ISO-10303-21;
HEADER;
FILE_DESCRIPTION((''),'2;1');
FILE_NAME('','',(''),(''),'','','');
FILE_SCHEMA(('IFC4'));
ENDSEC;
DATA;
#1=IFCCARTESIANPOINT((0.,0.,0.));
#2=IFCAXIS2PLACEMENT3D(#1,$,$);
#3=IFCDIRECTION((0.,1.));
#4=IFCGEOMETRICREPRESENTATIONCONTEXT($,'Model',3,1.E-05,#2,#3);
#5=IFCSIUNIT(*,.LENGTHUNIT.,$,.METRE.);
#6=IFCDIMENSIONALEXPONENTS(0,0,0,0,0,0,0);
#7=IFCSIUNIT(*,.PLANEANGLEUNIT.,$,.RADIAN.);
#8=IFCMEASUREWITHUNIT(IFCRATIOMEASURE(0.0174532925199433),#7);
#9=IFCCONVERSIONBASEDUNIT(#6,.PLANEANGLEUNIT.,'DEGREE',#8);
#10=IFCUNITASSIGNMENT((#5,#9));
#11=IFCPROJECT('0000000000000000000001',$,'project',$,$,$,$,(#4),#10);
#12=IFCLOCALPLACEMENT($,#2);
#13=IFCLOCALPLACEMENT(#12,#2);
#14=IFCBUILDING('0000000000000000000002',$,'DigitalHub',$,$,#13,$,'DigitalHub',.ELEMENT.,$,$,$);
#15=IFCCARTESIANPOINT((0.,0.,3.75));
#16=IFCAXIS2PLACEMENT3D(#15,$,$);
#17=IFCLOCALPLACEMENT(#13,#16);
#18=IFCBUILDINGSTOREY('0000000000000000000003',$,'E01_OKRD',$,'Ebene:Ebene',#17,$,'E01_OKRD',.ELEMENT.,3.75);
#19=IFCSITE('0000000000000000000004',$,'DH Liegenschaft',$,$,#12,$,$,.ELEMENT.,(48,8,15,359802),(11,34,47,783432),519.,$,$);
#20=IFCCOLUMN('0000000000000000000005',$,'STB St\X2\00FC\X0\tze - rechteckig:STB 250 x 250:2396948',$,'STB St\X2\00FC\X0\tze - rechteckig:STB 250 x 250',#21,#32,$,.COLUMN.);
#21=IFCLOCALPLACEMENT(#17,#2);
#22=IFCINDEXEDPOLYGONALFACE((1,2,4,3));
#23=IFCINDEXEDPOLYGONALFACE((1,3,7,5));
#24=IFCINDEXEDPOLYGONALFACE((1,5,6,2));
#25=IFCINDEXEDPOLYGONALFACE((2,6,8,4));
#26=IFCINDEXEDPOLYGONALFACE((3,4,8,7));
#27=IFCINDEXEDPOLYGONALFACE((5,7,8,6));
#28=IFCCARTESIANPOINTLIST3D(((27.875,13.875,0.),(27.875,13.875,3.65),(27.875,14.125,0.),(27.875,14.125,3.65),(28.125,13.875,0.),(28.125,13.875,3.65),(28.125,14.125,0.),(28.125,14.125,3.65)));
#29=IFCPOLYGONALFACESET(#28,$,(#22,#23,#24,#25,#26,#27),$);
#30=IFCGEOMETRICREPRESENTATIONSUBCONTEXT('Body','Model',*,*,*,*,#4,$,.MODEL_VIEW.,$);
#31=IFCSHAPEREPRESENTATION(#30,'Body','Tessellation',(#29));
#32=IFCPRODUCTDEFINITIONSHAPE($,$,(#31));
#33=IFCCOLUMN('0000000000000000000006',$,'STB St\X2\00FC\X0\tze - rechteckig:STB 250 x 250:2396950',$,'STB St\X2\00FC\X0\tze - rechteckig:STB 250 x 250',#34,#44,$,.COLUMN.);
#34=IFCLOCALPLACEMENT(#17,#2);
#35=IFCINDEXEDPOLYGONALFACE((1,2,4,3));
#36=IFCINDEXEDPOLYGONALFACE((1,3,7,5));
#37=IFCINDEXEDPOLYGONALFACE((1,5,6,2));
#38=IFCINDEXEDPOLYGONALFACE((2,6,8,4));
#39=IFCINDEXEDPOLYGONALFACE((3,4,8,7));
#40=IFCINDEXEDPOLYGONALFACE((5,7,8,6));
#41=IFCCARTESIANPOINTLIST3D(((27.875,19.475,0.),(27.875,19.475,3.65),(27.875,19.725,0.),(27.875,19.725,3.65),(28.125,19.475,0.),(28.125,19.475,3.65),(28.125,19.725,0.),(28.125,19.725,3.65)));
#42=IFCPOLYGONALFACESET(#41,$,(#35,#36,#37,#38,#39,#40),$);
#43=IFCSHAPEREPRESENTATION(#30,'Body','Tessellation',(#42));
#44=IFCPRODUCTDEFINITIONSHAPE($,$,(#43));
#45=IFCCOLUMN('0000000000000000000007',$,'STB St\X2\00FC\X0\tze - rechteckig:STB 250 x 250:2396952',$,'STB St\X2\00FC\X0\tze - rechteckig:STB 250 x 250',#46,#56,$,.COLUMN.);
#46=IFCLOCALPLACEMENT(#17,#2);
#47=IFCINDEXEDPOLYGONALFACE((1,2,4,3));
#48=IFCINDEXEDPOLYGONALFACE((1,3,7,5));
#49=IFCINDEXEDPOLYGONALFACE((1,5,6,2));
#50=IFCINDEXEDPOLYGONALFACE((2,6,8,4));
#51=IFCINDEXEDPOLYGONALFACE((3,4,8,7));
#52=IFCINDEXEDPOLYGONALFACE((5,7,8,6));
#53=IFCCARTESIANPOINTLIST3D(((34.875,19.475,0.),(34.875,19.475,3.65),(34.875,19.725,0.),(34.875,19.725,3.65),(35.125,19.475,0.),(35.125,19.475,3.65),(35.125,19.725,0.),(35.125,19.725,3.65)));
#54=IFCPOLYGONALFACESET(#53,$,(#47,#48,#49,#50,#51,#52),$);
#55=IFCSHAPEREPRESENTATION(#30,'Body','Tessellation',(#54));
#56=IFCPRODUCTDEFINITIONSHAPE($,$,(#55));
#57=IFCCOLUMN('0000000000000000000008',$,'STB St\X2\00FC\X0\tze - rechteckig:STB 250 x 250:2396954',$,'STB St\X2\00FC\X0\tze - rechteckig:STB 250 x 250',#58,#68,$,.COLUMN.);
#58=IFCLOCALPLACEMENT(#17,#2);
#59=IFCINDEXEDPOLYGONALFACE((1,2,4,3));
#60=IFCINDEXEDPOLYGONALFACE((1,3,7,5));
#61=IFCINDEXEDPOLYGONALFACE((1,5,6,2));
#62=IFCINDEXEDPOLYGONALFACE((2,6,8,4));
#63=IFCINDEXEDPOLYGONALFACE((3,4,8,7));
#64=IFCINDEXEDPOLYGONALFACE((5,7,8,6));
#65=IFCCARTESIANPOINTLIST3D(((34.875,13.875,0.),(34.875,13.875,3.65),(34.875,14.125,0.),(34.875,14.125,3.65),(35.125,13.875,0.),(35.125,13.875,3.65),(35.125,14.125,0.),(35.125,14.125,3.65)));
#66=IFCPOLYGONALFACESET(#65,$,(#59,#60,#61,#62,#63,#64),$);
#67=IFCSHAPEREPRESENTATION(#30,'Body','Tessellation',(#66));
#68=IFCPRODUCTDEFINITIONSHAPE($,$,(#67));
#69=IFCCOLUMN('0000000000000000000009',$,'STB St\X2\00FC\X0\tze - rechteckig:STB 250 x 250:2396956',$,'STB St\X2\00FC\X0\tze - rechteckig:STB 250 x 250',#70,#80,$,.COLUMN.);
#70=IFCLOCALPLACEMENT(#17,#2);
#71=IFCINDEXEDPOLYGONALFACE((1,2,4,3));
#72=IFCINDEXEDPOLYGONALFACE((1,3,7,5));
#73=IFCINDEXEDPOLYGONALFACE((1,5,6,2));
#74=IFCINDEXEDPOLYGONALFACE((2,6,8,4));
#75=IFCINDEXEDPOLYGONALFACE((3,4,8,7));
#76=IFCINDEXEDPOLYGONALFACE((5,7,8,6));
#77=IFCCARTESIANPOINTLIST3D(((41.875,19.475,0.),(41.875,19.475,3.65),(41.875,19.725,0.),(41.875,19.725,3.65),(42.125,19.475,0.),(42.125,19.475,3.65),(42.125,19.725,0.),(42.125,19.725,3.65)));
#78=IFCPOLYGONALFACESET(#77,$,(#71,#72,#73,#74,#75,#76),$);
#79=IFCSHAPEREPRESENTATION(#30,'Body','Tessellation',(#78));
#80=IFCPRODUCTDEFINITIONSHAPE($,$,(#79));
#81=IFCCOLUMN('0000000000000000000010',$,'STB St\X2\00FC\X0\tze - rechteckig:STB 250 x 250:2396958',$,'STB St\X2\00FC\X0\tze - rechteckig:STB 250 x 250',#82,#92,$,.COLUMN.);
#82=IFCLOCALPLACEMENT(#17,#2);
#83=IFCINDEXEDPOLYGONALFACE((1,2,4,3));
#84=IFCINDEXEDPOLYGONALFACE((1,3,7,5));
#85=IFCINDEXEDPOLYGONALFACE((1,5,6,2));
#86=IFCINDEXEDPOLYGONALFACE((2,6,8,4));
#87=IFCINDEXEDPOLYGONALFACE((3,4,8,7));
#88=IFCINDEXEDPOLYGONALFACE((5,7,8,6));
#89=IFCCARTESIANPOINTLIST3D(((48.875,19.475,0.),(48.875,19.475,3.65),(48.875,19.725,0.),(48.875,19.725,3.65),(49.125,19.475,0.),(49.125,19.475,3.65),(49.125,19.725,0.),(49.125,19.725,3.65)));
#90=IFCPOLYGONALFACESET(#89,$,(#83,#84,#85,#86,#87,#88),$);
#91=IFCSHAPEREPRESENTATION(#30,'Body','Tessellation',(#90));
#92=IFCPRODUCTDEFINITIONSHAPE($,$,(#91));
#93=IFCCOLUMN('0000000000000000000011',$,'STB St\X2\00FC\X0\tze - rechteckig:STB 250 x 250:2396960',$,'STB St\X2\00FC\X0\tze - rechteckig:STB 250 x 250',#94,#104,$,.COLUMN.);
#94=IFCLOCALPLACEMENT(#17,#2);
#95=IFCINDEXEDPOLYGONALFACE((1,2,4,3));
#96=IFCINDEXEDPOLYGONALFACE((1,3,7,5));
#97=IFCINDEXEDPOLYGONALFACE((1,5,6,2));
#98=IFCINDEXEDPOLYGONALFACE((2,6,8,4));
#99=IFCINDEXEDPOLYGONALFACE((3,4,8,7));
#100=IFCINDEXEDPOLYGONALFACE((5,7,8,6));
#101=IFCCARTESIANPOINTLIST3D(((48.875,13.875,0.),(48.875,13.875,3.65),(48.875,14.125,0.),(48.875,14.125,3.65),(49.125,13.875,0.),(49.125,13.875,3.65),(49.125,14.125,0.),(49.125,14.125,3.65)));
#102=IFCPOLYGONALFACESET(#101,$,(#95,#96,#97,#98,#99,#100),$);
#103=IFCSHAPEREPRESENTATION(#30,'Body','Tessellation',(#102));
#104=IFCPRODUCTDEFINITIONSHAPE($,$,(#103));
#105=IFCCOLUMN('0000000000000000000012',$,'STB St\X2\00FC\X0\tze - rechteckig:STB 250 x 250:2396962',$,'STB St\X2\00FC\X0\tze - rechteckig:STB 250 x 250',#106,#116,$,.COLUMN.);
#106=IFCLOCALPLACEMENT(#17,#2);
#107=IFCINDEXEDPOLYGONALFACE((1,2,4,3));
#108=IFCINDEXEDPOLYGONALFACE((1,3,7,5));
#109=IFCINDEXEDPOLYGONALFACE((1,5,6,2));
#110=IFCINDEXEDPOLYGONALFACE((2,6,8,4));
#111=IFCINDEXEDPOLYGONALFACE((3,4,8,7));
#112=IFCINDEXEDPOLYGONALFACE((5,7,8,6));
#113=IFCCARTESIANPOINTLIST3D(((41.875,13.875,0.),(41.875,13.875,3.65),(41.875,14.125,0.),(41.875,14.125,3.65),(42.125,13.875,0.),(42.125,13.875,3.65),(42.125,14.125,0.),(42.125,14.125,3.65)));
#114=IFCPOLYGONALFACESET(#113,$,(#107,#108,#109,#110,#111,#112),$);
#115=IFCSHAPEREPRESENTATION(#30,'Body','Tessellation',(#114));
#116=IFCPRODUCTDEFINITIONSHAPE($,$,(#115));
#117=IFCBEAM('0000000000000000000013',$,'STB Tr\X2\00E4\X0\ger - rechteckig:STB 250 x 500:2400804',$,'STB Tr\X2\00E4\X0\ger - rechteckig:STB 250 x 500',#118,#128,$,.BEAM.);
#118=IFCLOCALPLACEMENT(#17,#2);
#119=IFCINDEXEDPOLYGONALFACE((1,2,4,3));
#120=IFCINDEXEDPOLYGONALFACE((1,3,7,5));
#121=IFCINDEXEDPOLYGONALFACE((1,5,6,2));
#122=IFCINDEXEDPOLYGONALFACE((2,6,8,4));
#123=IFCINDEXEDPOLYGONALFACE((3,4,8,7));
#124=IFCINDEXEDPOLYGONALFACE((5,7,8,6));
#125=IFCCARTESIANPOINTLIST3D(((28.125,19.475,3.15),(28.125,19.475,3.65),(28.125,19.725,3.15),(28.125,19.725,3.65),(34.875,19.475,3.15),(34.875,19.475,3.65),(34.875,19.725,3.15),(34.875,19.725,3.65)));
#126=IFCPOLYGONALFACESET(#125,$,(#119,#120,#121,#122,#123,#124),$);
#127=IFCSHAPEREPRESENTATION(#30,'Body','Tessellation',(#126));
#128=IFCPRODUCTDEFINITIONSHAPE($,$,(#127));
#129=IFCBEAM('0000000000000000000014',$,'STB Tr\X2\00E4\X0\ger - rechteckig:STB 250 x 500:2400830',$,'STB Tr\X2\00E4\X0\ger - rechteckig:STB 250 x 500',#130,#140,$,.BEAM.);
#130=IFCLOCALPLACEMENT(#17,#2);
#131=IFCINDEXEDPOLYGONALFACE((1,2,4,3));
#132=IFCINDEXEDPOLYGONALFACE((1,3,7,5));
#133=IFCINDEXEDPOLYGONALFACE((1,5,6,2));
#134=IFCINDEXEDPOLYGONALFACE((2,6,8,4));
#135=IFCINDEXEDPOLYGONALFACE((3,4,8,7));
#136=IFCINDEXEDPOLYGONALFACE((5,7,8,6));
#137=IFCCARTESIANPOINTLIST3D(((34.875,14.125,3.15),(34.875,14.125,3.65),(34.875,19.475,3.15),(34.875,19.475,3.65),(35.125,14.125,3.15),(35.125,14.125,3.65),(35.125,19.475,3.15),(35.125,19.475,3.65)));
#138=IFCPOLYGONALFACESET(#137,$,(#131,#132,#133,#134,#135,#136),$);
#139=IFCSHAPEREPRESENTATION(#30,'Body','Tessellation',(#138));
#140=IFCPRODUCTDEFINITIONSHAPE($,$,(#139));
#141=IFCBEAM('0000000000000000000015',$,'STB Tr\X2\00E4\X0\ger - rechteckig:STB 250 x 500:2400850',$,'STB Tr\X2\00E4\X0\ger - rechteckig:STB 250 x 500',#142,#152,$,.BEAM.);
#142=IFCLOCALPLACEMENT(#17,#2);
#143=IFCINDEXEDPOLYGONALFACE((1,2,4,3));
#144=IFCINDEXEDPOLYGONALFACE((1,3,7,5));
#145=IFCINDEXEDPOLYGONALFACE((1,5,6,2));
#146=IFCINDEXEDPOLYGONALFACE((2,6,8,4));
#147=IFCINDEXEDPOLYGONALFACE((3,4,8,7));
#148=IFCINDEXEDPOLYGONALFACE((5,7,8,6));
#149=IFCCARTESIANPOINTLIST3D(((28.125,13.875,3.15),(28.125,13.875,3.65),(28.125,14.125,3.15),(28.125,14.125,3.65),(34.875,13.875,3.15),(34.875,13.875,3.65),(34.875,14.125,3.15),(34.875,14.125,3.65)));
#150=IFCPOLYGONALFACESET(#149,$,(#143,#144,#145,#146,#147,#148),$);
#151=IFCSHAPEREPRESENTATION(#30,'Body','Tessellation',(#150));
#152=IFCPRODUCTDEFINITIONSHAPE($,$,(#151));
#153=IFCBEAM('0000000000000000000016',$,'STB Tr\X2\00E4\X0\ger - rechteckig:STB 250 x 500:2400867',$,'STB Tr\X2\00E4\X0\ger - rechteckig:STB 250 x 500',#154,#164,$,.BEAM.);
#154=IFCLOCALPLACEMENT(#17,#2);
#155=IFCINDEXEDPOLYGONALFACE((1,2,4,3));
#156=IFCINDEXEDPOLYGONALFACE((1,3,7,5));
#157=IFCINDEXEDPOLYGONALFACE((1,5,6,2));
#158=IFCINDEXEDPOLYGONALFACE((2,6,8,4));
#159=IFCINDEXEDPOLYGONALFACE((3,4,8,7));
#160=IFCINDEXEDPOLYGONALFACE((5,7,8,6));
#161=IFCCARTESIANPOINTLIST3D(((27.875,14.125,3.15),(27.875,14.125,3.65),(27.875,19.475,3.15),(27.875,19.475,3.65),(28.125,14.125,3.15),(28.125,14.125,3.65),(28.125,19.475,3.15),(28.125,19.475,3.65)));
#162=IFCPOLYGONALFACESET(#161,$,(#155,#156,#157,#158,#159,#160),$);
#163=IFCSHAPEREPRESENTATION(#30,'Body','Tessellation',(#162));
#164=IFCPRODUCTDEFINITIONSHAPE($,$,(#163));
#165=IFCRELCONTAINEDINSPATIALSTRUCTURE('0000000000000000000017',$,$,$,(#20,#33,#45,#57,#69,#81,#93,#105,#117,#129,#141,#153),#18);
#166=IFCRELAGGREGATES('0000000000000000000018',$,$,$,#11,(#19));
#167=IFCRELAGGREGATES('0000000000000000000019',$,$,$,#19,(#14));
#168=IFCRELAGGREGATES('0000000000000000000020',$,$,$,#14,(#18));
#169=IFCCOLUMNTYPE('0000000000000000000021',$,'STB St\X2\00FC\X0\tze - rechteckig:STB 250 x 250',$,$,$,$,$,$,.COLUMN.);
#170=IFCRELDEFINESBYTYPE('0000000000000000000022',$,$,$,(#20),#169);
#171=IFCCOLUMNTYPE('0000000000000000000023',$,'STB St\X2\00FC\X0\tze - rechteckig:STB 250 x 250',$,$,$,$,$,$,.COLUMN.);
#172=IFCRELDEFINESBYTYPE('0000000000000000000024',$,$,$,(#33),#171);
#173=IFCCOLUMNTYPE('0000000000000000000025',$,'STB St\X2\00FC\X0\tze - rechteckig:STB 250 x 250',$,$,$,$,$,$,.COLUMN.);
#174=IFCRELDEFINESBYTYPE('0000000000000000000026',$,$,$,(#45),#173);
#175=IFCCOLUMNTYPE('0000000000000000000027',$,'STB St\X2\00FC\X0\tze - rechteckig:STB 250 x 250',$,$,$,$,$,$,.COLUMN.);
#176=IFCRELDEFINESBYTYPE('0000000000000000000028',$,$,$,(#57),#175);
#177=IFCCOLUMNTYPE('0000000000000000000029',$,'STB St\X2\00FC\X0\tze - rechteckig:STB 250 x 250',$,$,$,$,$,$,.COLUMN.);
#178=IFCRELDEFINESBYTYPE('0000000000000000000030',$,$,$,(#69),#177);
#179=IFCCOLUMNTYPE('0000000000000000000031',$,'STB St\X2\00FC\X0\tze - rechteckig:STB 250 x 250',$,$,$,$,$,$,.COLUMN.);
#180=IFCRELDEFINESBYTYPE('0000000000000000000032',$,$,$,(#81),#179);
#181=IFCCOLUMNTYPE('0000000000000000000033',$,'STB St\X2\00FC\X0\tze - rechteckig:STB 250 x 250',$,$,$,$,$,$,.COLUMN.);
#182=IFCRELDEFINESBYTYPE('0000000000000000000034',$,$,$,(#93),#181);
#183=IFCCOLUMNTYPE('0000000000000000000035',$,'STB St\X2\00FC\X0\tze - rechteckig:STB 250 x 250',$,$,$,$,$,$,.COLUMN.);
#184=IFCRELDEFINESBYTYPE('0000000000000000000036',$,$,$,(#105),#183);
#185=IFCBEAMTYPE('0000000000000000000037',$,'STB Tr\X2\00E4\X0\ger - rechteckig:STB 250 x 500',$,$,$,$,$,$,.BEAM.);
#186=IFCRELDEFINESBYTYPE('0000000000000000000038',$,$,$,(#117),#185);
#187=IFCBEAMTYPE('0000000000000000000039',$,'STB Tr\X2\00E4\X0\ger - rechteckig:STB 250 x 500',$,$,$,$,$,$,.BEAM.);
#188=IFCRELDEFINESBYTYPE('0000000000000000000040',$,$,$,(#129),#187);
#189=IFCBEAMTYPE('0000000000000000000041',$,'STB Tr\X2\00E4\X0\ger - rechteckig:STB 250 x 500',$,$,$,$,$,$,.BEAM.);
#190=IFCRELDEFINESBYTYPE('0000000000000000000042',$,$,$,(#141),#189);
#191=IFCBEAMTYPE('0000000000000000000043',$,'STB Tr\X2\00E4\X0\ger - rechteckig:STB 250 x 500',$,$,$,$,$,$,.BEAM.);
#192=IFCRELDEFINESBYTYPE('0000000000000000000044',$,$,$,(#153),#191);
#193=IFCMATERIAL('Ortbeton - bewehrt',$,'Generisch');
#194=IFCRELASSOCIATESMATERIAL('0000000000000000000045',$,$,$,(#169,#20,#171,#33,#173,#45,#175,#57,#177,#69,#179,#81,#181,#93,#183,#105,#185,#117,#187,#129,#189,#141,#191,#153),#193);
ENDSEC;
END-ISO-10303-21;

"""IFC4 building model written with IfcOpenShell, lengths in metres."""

from ifc_helpers import new_model, entity, si_unit, converted_unit, direction, frame, origin, place, context, subcontext, project, spatial, indexed_curve, outline, extrude, source, transform, mapped, material, type_object, type_shapes, element, save


model = new_model("IFC4")

# Units and contexts
model_context = context("Model", 3, precision=1e-05, world=origin(), true_north=direction((0.0, 1.0)))
body_context = subcontext(model_context, "Body", "Model", "MODEL_VIEW")
ifc_project = project(units=[si_unit("LENGTHUNIT", "METRE"), converted_unit("PLANEANGLEUNIT", "DEGREE", entity("IfcRatioMeasure", 0.0174532925199433), si_unit("PLANEANGLEUNIT", "RADIAN"), dimensions=[0, 0, 0, 0, 0, 0, 0])], contexts=[model_context])

# Site, building, storey
site_placement = place(None, frame((0.0, 0.0, 0.0)))
site = spatial("IfcSite", under=ifc_project, at=site_placement, Name="DH Liegenschaft", CompositionType="ELEMENT", RefLatitude=(48, 8, 15, 359802), RefLongitude=(11, 34, 47, 783432), RefElevation=519.0)
building_placement = place(site_placement, origin())
building = spatial("IfcBuilding", under=site, at=building_placement, Name="DigitalHub", LongName="DigitalHub", CompositionType="ELEMENT")
storey_placement = place(building_placement, frame((0.0, 0.0, 3.75)))
storey = spatial("IfcBuildingStorey", under=building, at=storey_placement, Name="E01_OKRD", ObjectType="Ebene:Ebene", LongName="E01_OKRD", CompositionType="ELEMENT", Elevation=3.75)

# Columns
ifc_material = material(Name="Ortbeton - bewehrt", Category="Generisch")
column_type_1 = type_object("IfcColumnType", Name="STB Stütze - rechteckig:STB 250 x 250", PredefinedType="COLUMN", material=ifc_material)
shared_shape_1 = source(origin(), body_context, "Body", "SweptSolid", [
    extrude(outline(indexed_curve([(-0.125, -0.125), (0.125, -0.125), (0.125, 0.125), (-0.125, 0.125), (-0.125, -0.125)], self_intersect=False)), frame((28.0, 14.0, 3.75), z_axis=(0.0, 0.0, 1.0), x_axis=(0.0, -1.0, 0.0)), (0.0, 0.0, 1.0), 3.65),
])
type_shapes(column_type_1, [shared_shape_1])
column_1_placement = place(storey_placement, frame((0.0, 0.0, -3.75)))
element("IfcColumn", 1, at=column_1_placement, inside=storey, type_object=column_type_1, material=ifc_material, Name="STB Stütze - rechteckig:STB 250 x 250:2396948", ObjectType="STB Stütze - rechteckig:STB 250 x 250", PredefinedType="COLUMN", context=body_context, shape_type="MappedRepresentation", body=[
    mapped(shared_shape_1, transform((0.0, 0.0, 0.0), scale=1.0)),
])
column_type_2 = type_object("IfcColumnType", Name="STB Stütze - rechteckig:STB 250 x 250", PredefinedType="COLUMN", material=ifc_material)
shared_shape_2 = source(origin(), body_context, "Body", "SweptSolid", [
    extrude(outline(indexed_curve([(-0.125, -0.125), (0.125, -0.125), (0.125, 0.125), (-0.125, 0.125), (-0.125, -0.125)], self_intersect=False)), frame((28.0, 19.6, 3.75), z_axis=(0.0, 0.0, 1.0), x_axis=(0.0, -1.0, 0.0)), (0.0, 0.0, 1.0), 3.65),
])
type_shapes(column_type_2, [shared_shape_2])
column_2_placement = place(storey_placement, frame((0.0, 0.0, -3.75)))
element("IfcColumn", 2, at=column_2_placement, inside=storey, type_object=column_type_2, material=ifc_material, Name="STB Stütze - rechteckig:STB 250 x 250:2396950", ObjectType="STB Stütze - rechteckig:STB 250 x 250", PredefinedType="COLUMN", context=body_context, shape_type="MappedRepresentation", body=[
    mapped(shared_shape_2, transform((0.0, 0.0, 0.0), scale=1.0)),
])
column_type_3 = type_object("IfcColumnType", Name="STB Stütze - rechteckig:STB 250 x 250", PredefinedType="COLUMN", material=ifc_material)
shared_shape_3 = source(origin(), body_context, "Body", "SweptSolid", [
    extrude(outline(indexed_curve([(-0.125, -0.125), (0.125, -0.125), (0.125, 0.125), (-0.125, 0.125), (-0.125, -0.125)], self_intersect=False)), frame((35.0, 19.6, 3.75), z_axis=(0.0, 0.0, 1.0), x_axis=(0.0, -1.0, 0.0)), (0.0, 0.0, 1.0), 3.65),
])
type_shapes(column_type_3, [shared_shape_3])
column_3_placement = place(storey_placement, frame((0.0, 0.0, -3.75)))
element("IfcColumn", 3, at=column_3_placement, inside=storey, type_object=column_type_3, material=ifc_material, Name="STB Stütze - rechteckig:STB 250 x 250:2396952", ObjectType="STB Stütze - rechteckig:STB 250 x 250", PredefinedType="COLUMN", context=body_context, shape_type="MappedRepresentation", body=[
    mapped(shared_shape_3, transform((0.0, 0.0, 0.0), scale=1.0)),
])
column_type_4 = type_object("IfcColumnType", Name="STB Stütze - rechteckig:STB 250 x 250", PredefinedType="COLUMN", material=ifc_material)
shared_shape_4 = source(origin(), body_context, "Body", "SweptSolid", [
    extrude(outline(indexed_curve([(-0.125, -0.125), (0.125, -0.125), (0.125, 0.125), (-0.125, 0.125), (-0.125, -0.125)], self_intersect=False)), frame((35.0, 14.0, 3.75), z_axis=(0.0, 0.0, 1.0), x_axis=(0.0, -1.0, 0.0)), (0.0, 0.0, 1.0), 3.65),
])
type_shapes(column_type_4, [shared_shape_4])
column_4_placement = place(storey_placement, frame((0.0, 0.0, -3.75)))
element("IfcColumn", 4, at=column_4_placement, inside=storey, type_object=column_type_4, material=ifc_material, Name="STB Stütze - rechteckig:STB 250 x 250:2396954", ObjectType="STB Stütze - rechteckig:STB 250 x 250", PredefinedType="COLUMN", context=body_context, shape_type="MappedRepresentation", body=[
    mapped(shared_shape_4, transform((0.0, 0.0, 0.0), scale=1.0)),
])
column_type_5 = type_object("IfcColumnType", Name="STB Stütze - rechteckig:STB 250 x 250", PredefinedType="COLUMN", material=ifc_material)
shared_shape_5 = source(origin(), body_context, "Body", "SweptSolid", [
    extrude(outline(indexed_curve([(-0.125, -0.125), (0.125, -0.125), (0.125, 0.125), (-0.125, 0.125), (-0.125, -0.125)], self_intersect=False)), frame((42.0, 19.6, 3.75), z_axis=(0.0, 0.0, 1.0), x_axis=(0.0, -1.0, 0.0)), (0.0, 0.0, 1.0), 3.65),
])
type_shapes(column_type_5, [shared_shape_5])
column_5_placement = place(storey_placement, frame((0.0, 0.0, -3.75)))
element("IfcColumn", 5, at=column_5_placement, inside=storey, type_object=column_type_5, material=ifc_material, Name="STB Stütze - rechteckig:STB 250 x 250:2396956", ObjectType="STB Stütze - rechteckig:STB 250 x 250", PredefinedType="COLUMN", context=body_context, shape_type="MappedRepresentation", body=[
    mapped(shared_shape_5, transform((0.0, 0.0, 0.0), scale=1.0)),
])
column_type_6 = type_object("IfcColumnType", Name="STB Stütze - rechteckig:STB 250 x 250", PredefinedType="COLUMN", material=ifc_material)
shared_shape_6 = source(origin(), body_context, "Body", "SweptSolid", [
    extrude(outline(indexed_curve([(-0.125, -0.125), (0.125, -0.125), (0.125, 0.125), (-0.125, 0.125), (-0.125, -0.125)], self_intersect=False)), frame((49.0, 19.6, 3.75), z_axis=(0.0, 0.0, 1.0), x_axis=(0.0, -1.0, 0.0)), (0.0, 0.0, 1.0), 3.65),
])
type_shapes(column_type_6, [shared_shape_6])
column_6_placement = place(storey_placement, frame((0.0, 0.0, -3.75)))
element("IfcColumn", 6, at=column_6_placement, inside=storey, type_object=column_type_6, material=ifc_material, Name="STB Stütze - rechteckig:STB 250 x 250:2396958", ObjectType="STB Stütze - rechteckig:STB 250 x 250", PredefinedType="COLUMN", context=body_context, shape_type="MappedRepresentation", body=[
    mapped(shared_shape_6, transform((0.0, 0.0, 0.0), scale=1.0)),
])
column_type_7 = type_object("IfcColumnType", Name="STB Stütze - rechteckig:STB 250 x 250", PredefinedType="COLUMN", material=ifc_material)
shared_shape_7 = source(origin(), body_context, "Body", "SweptSolid", [
    extrude(outline(indexed_curve([(-0.125, -0.125), (0.125, -0.125), (0.125, 0.125), (-0.125, 0.125), (-0.125, -0.125)], self_intersect=False)), frame((49.0, 14.0, 3.75), z_axis=(0.0, 0.0, 1.0), x_axis=(0.0, -1.0, 0.0)), (0.0, 0.0, 1.0), 3.65),
])
type_shapes(column_type_7, [shared_shape_7])
column_7_placement = place(storey_placement, frame((0.0, 0.0, -3.75)))
element("IfcColumn", 7, at=column_7_placement, inside=storey, type_object=column_type_7, material=ifc_material, Name="STB Stütze - rechteckig:STB 250 x 250:2396960", ObjectType="STB Stütze - rechteckig:STB 250 x 250", PredefinedType="COLUMN", context=body_context, shape_type="MappedRepresentation", body=[
    mapped(shared_shape_7, transform((0.0, 0.0, 0.0), scale=1.0)),
])
column_type_8 = type_object("IfcColumnType", Name="STB Stütze - rechteckig:STB 250 x 250", PredefinedType="COLUMN", material=ifc_material)
shared_shape_8 = source(origin(), body_context, "Body", "SweptSolid", [
    extrude(outline(indexed_curve([(-0.125, -0.125), (0.125, -0.125), (0.125, 0.125), (-0.125, 0.125), (-0.125, -0.125)], self_intersect=False)), frame((42.0, 14.0, 3.75), z_axis=(0.0, 0.0, 1.0), x_axis=(0.0, -1.0, 0.0)), (0.0, 0.0, 1.0), 3.65),
])
type_shapes(column_type_8, [shared_shape_8])
column_8_placement = place(storey_placement, frame((0.0, 0.0, -3.75)))
element("IfcColumn", 8, at=column_8_placement, inside=storey, type_object=column_type_8, material=ifc_material, Name="STB Stütze - rechteckig:STB 250 x 250:2396962", ObjectType="STB Stütze - rechteckig:STB 250 x 250", PredefinedType="COLUMN", context=body_context, shape_type="MappedRepresentation", body=[
    mapped(shared_shape_8, transform((0.0, 0.0, 0.0), scale=1.0)),
])

# Beams
beam_type_1 = type_object("IfcBeamType", Name="STB Träger - rechteckig:STB 250 x 500", PredefinedType="BEAM", material=ifc_material)
shared_shape_9 = source(origin(), body_context, "Body", "SweptSolid", [
    extrude(outline(indexed_curve([(-0.25, -0.125), (0.25, -0.125), (0.25, 0.125), (-0.25, 0.125), (-0.25, -0.125)], self_intersect=False)), frame((28.125, 19.6, 7.15), z_axis=(1.0, 0.0, 0.0), x_axis=(0.0, 0.0, -1.0)), (0.0, 0.0, 1.0), 6.75),
])
type_shapes(beam_type_1, [shared_shape_9])
beam_1_placement = place(storey_placement, frame((0.0, 0.0, -3.75)))
element("IfcBeam", 9, at=beam_1_placement, inside=storey, type_object=beam_type_1, material=ifc_material, Name="STB Träger - rechteckig:STB 250 x 500:2400804", ObjectType="STB Träger - rechteckig:STB 250 x 500", PredefinedType="BEAM", context=body_context, shape_type="MappedRepresentation", body=[
    mapped(shared_shape_9, transform((0.0, 0.0, 0.0), scale=1.0)),
])
beam_type_2 = type_object("IfcBeamType", Name="STB Träger - rechteckig:STB 250 x 500", PredefinedType="BEAM", material=ifc_material)
shared_shape_10 = source(origin(), body_context, "Body", "SweptSolid", [
    extrude(outline(indexed_curve([(-0.125, -0.25), (0.125, -0.25), (0.125, 0.25), (-0.125, 0.25), (-0.125, -0.25)], self_intersect=False)), frame((35.0, 19.475, 7.15), z_axis=(0.0, -1.0, 0.0), x_axis=(-1.0, 0.0, 0.0)), (0.0, 0.0, 1.0), 5.35),
])
type_shapes(beam_type_2, [shared_shape_10])
beam_2_placement = place(storey_placement, frame((0.0, 0.0, -3.75)))
element("IfcBeam", 10, at=beam_2_placement, inside=storey, type_object=beam_type_2, material=ifc_material, Name="STB Träger - rechteckig:STB 250 x 500:2400830", ObjectType="STB Träger - rechteckig:STB 250 x 500", PredefinedType="BEAM", context=body_context, shape_type="MappedRepresentation", body=[
    mapped(shared_shape_10, transform((0.0, 0.0, 0.0), scale=1.0)),
])
beam_type_3 = type_object("IfcBeamType", Name="STB Träger - rechteckig:STB 250 x 500", PredefinedType="BEAM", material=ifc_material)
shared_shape_11 = source(origin(), body_context, "Body", "SweptSolid", [
    extrude(outline(indexed_curve([(-0.25, -0.125), (0.25, -0.125), (0.25, 0.125), (-0.25, 0.125), (-0.25, -0.125)], self_intersect=False)), frame((34.875, 14.0, 7.15), z_axis=(-1.0, 0.0, 0.0), x_axis=(0.0, 0.0, -1.0)), (0.0, 0.0, 1.0), 6.75),
])
type_shapes(beam_type_3, [shared_shape_11])
beam_3_placement = place(storey_placement, frame((0.0, 0.0, -3.75)))
element("IfcBeam", 11, at=beam_3_placement, inside=storey, type_object=beam_type_3, material=ifc_material, Name="STB Träger - rechteckig:STB 250 x 500:2400850", ObjectType="STB Träger - rechteckig:STB 250 x 500", PredefinedType="BEAM", context=body_context, shape_type="MappedRepresentation", body=[
    mapped(shared_shape_11, transform((0.0, 0.0, 0.0), scale=1.0)),
])
beam_type_4 = type_object("IfcBeamType", Name="STB Träger - rechteckig:STB 250 x 500", PredefinedType="BEAM", material=ifc_material)
shared_shape_12 = source(origin(), body_context, "Body", "SweptSolid", [
    extrude(outline(indexed_curve([(-0.125, -0.25), (0.125, -0.25), (0.125, 0.25), (-0.125, 0.25), (-0.125, -0.25)], self_intersect=False)), frame((28.0, 14.125, 7.15), z_axis=(0.0, 1.0, 0.0), x_axis=(-1.0, 0.0, 0.0)), (0.0, 0.0, 1.0), 5.35),
])
type_shapes(beam_type_4, [shared_shape_12])
beam_4_placement = place(storey_placement, frame((0.0, 0.0, -3.75)))
element("IfcBeam", 12, at=beam_4_placement, inside=storey, type_object=beam_type_4, material=ifc_material, Name="STB Träger - rechteckig:STB 250 x 500:2400867", ObjectType="STB Träger - rechteckig:STB 250 x 500", PredefinedType="BEAM", context=body_context, shape_type="MappedRepresentation", body=[
    mapped(shared_shape_12, transform((0.0, 0.0, 0.0), scale=1.0)),
])

save(model, "model.ifc")
